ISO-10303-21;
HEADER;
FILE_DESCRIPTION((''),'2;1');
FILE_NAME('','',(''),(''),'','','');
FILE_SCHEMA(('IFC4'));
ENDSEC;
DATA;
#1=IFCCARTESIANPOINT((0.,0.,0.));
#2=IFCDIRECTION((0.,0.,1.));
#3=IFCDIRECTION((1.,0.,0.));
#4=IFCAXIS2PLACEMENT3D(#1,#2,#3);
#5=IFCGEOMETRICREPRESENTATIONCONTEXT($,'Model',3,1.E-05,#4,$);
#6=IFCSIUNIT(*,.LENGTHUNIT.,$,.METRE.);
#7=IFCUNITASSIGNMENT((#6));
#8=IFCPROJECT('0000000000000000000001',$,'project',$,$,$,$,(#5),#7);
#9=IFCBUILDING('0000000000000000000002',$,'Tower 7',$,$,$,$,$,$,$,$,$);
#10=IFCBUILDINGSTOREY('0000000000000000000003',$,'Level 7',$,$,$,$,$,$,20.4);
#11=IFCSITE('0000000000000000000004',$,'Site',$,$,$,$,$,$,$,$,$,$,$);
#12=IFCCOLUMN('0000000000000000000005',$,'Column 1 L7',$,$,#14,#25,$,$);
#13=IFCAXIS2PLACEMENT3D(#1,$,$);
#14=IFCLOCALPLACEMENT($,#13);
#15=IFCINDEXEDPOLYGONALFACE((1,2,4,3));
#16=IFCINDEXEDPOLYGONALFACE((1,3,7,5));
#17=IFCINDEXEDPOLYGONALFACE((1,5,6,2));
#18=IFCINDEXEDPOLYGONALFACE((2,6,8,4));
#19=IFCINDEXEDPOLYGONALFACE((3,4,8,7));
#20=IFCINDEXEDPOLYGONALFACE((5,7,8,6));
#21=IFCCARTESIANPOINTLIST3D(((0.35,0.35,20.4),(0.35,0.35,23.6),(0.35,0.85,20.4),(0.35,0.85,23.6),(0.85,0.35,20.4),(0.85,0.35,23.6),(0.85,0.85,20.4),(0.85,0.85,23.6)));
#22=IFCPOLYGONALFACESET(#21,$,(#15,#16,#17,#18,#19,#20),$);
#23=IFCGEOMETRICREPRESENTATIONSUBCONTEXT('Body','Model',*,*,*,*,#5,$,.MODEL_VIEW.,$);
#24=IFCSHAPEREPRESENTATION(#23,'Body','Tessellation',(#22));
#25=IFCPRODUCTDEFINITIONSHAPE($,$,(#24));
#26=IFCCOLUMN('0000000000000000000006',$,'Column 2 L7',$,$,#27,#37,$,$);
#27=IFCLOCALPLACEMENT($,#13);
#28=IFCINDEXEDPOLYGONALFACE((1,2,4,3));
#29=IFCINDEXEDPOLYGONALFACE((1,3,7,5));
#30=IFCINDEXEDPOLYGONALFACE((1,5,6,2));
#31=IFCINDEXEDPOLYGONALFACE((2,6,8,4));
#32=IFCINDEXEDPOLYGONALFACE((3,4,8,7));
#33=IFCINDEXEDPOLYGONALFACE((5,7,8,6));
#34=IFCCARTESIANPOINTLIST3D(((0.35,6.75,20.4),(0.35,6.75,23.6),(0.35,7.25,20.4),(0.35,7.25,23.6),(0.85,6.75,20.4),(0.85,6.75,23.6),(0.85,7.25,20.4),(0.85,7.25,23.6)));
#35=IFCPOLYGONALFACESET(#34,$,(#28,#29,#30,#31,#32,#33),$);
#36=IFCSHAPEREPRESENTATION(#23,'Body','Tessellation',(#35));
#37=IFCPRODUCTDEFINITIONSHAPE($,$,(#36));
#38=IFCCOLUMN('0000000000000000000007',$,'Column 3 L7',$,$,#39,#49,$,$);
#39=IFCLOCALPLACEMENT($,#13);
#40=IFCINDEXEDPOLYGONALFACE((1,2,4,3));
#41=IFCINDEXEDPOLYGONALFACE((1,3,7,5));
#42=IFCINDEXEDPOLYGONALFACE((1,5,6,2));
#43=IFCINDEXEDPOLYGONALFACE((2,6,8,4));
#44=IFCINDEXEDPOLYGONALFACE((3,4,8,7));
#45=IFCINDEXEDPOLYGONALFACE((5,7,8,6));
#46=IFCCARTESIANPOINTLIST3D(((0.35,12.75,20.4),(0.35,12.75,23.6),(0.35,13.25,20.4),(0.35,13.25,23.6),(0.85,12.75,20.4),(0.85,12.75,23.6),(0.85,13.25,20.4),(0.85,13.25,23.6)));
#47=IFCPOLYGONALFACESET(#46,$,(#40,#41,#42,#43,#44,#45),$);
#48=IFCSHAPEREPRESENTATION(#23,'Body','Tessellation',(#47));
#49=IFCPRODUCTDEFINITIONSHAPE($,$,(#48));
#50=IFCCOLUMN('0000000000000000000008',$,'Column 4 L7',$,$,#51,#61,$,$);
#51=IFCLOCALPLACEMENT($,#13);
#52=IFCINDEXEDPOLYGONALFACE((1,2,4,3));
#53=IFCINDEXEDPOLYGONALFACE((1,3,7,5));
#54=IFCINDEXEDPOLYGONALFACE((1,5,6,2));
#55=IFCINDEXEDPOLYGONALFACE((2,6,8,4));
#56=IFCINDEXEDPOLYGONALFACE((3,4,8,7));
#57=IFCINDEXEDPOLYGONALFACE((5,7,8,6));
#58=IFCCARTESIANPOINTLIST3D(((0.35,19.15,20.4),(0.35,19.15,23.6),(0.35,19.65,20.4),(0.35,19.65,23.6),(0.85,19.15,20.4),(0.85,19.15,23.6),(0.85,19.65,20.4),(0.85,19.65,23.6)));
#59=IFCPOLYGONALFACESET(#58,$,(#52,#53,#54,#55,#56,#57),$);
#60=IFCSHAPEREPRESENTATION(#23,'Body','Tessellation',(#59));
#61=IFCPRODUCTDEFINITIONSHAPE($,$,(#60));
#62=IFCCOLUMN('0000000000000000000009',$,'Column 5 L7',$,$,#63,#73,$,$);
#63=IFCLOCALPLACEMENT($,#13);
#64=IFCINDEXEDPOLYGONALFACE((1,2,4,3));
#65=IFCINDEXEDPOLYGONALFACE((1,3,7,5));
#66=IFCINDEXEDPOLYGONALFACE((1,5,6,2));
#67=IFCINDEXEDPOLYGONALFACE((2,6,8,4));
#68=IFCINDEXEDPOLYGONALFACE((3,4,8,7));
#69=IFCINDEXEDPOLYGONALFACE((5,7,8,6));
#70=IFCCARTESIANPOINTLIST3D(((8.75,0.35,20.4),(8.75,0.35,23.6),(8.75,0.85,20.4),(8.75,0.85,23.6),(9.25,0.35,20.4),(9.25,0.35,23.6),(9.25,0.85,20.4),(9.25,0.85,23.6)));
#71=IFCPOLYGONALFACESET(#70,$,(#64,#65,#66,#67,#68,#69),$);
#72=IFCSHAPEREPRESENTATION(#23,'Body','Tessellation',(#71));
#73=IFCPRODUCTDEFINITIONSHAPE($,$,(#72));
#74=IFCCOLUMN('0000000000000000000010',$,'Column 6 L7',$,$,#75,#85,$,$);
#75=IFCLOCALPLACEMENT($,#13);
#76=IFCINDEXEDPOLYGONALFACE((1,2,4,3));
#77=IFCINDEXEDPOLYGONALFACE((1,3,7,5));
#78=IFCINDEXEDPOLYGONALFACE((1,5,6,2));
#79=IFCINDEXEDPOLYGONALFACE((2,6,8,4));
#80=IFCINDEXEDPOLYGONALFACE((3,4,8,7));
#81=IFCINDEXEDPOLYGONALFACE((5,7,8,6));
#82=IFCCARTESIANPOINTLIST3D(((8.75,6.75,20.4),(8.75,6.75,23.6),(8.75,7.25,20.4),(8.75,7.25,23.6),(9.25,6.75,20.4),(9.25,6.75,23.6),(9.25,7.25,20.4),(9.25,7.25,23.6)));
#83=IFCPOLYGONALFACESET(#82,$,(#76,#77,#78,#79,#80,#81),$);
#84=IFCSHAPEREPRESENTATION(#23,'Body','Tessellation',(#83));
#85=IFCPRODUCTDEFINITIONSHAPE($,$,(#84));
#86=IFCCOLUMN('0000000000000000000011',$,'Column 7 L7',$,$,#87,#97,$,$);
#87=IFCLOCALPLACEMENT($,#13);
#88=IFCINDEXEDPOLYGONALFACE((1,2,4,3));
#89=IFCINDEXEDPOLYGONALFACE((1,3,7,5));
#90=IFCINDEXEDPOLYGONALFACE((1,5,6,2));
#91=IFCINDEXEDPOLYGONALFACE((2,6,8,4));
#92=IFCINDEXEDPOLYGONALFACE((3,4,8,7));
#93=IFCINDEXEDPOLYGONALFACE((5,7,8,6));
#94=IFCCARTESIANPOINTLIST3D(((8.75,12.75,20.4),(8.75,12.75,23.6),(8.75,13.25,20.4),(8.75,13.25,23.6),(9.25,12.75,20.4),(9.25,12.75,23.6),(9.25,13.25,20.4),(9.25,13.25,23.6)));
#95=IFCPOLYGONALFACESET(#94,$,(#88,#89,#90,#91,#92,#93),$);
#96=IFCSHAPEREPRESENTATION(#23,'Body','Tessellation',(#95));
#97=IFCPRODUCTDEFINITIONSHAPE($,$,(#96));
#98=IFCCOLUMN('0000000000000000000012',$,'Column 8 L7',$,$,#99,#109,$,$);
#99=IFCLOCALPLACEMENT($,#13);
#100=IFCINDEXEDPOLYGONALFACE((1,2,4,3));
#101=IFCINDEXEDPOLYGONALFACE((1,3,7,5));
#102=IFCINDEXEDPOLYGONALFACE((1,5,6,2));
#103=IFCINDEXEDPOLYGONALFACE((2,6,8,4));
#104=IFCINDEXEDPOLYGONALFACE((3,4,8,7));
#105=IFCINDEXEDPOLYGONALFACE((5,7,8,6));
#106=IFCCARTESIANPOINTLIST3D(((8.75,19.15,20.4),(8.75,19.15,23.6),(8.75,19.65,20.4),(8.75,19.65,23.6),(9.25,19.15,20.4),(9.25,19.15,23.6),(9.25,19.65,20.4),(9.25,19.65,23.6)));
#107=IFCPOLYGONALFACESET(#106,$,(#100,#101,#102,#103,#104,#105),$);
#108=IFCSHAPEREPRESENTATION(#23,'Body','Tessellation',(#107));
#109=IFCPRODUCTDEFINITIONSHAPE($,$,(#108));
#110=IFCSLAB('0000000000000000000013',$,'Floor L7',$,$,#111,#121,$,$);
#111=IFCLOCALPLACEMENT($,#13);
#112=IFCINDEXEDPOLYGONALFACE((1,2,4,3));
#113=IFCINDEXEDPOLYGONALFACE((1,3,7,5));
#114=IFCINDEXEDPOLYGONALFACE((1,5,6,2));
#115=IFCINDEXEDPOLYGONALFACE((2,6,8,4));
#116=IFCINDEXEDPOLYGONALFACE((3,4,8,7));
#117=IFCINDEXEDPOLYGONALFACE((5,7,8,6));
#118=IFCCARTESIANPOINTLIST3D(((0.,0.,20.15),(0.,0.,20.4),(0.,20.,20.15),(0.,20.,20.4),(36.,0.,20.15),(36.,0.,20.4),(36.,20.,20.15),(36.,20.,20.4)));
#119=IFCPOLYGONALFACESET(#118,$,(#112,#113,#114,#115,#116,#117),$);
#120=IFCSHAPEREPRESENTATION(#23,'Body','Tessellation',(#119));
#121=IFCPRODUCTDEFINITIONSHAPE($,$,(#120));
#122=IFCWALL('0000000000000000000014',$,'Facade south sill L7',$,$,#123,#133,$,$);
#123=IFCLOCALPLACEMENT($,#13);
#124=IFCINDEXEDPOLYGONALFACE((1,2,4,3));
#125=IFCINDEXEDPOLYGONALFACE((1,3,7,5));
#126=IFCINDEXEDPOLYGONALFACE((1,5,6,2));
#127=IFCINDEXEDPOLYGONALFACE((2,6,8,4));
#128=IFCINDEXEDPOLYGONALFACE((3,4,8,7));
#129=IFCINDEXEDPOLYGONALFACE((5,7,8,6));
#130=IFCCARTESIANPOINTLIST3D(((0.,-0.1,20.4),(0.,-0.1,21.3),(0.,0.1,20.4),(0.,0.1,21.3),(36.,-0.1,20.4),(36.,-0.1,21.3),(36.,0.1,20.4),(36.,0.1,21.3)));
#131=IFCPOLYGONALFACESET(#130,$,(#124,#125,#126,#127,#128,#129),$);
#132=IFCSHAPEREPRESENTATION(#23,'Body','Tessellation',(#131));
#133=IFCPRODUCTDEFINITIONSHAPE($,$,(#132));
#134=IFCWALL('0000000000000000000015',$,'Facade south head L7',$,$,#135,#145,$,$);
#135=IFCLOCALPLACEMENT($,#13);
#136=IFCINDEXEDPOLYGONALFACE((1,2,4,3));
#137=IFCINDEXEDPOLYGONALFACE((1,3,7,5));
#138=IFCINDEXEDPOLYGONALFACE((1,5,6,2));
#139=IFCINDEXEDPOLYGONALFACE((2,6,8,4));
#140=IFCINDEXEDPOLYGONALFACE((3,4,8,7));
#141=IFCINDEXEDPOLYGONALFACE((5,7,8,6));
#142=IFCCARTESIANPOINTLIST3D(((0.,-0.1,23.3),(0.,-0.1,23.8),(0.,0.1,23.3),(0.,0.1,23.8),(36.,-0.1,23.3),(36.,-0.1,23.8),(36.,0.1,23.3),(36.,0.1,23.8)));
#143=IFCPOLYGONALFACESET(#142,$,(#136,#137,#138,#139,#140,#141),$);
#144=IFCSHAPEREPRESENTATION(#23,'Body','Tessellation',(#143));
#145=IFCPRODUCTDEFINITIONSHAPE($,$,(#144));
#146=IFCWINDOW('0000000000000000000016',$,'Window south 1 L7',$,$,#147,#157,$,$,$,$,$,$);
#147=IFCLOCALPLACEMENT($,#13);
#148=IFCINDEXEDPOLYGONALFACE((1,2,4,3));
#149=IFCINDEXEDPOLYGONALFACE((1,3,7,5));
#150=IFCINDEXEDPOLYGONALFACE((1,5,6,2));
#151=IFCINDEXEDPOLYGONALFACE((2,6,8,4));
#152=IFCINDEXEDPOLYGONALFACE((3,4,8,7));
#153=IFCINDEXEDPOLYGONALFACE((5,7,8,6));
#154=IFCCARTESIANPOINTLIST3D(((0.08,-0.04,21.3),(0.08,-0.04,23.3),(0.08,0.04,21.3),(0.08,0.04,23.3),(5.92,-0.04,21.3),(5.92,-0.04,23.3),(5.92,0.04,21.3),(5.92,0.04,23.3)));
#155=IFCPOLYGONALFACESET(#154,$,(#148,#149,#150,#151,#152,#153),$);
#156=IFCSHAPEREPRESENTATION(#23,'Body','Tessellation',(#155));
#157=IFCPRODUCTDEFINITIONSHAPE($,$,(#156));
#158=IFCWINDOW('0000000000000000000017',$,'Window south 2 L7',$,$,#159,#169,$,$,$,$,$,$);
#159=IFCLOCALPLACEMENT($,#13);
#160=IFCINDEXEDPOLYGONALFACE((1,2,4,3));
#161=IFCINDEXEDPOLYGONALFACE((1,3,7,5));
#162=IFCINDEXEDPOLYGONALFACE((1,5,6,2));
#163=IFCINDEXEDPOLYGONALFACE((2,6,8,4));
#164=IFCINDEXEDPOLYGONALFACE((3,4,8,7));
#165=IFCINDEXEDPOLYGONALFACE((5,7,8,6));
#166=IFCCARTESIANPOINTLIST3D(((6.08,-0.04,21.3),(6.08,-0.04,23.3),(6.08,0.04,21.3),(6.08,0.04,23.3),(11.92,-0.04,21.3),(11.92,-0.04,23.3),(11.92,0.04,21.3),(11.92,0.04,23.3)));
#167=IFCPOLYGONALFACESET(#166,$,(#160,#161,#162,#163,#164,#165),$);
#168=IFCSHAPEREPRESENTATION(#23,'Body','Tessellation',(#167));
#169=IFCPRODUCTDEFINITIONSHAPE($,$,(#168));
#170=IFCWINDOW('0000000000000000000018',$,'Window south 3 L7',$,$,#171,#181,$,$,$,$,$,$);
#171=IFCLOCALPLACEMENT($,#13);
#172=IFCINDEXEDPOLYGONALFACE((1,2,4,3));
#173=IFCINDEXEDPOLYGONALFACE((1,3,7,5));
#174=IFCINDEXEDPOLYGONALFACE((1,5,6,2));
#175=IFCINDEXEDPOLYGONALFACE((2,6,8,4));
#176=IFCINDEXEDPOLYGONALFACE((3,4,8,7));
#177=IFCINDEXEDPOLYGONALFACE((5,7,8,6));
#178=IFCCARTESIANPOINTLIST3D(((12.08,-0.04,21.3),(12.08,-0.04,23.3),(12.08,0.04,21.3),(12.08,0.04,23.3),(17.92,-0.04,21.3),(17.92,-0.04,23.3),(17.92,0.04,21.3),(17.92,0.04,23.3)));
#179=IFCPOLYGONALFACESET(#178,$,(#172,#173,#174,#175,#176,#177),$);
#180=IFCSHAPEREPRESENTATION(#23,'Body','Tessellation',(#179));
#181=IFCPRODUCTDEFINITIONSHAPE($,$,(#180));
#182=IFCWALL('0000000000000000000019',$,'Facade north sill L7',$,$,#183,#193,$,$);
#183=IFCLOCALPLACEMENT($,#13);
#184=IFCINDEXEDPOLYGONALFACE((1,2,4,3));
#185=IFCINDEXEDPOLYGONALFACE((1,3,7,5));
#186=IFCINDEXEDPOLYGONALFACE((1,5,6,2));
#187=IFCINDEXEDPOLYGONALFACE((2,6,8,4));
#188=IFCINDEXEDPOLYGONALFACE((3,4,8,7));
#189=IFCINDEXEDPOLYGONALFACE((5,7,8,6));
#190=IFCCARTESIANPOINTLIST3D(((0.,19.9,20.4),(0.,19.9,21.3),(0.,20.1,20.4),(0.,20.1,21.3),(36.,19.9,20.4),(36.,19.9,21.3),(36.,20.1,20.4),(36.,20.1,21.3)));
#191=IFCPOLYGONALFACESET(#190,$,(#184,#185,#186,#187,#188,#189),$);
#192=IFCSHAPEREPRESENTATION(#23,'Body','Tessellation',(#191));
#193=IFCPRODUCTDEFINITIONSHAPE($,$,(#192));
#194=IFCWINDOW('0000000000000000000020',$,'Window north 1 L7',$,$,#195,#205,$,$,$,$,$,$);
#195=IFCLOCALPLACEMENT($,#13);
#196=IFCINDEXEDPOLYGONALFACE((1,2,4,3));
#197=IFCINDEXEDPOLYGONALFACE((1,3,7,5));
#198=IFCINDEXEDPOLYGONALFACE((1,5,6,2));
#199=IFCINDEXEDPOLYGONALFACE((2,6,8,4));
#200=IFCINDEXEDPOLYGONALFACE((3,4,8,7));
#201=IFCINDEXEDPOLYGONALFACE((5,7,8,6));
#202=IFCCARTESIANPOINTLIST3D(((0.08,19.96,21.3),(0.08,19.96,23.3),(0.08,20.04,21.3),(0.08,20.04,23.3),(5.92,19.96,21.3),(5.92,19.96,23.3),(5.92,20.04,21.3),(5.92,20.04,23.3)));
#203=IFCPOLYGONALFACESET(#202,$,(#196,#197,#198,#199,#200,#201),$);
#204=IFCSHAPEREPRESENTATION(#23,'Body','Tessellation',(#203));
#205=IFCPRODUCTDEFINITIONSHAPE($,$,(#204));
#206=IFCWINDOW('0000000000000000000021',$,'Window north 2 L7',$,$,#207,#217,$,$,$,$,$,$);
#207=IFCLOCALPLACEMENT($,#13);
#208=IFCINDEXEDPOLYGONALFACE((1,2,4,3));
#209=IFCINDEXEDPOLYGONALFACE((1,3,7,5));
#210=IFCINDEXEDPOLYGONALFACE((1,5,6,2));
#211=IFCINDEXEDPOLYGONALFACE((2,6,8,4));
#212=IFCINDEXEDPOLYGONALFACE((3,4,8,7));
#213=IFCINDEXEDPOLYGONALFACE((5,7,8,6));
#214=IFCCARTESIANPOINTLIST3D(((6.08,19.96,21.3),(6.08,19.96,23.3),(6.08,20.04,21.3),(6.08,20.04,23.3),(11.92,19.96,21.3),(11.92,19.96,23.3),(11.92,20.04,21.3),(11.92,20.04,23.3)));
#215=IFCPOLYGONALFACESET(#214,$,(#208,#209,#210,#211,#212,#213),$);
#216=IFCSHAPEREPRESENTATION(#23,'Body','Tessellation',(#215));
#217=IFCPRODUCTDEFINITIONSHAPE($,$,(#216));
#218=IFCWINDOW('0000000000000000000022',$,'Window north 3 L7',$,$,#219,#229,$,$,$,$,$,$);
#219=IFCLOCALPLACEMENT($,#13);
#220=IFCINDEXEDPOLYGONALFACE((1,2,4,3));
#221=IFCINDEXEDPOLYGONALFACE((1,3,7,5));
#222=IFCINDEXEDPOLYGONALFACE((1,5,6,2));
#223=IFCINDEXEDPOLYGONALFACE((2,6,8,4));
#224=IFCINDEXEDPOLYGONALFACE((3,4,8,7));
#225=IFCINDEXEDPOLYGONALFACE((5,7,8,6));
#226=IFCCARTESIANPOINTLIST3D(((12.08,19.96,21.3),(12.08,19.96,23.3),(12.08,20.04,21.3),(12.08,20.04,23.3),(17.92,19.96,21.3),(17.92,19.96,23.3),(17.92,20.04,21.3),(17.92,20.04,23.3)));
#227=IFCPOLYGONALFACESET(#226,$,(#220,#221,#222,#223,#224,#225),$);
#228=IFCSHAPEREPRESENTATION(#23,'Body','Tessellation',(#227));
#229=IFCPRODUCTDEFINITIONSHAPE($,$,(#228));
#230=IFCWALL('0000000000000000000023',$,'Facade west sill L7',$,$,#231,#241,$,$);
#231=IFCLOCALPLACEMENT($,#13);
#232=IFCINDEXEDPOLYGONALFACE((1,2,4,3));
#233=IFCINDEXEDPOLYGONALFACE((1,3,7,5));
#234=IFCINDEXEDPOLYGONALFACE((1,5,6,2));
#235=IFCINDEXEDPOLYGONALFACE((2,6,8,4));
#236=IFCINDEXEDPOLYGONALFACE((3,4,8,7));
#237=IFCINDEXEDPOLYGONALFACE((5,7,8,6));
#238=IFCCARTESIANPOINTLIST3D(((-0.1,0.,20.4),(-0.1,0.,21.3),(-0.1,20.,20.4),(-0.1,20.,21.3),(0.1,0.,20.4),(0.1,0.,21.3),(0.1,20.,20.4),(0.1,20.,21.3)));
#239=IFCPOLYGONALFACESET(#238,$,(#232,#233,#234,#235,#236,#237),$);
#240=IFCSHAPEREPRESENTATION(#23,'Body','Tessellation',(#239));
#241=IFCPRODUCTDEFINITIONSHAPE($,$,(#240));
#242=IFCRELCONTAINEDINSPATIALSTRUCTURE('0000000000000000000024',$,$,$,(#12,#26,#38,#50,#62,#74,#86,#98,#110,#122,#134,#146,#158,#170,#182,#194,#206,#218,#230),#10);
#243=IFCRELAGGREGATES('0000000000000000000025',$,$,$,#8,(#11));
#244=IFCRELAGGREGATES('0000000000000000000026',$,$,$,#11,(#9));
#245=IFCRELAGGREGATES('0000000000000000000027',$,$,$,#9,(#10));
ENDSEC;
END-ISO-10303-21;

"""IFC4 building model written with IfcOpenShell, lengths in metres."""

from ifc_helpers import new_model, si_unit, frame, origin, origin_with_axes, origin_2d, place, context, subcontext, project, spatial, rectangle, extrude, element, save


model = new_model("IFC4")

# Units and contexts
model_context = context("Model", 3, precision=1e-05, world=origin_with_axes())
body_context = subcontext(model_context, "Body", "Model", "MODEL_VIEW")
ifc_project = project(units=[si_unit("LENGTHUNIT", "METRE")], contexts=[model_context])

# Site, building, storey
site = spatial("IfcSite", under=ifc_project, Name="Site")
building = spatial("IfcBuilding", under=site, Name="Tower 7")
storey = spatial("IfcBuildingStorey", under=building, Name="Level 7", Elevation=20.4)

# Columns
for number, where, z_axis, x_axis, name in (
    (1, (0.6, 0.6, 20.4), (0.0, 0.0, 1.0), (1.0, 0.0, 0.0), "Column 1 L7"),
    (2, (0.6, 7.0, 20.4), (0.0, 0.0, 1.0), (1.0, 0.0, 0.0), "Column 2 L7"),
    (3, (0.6, 13.0, 20.4), (0.0, 0.0, 1.0), (1.0, 0.0, 0.0), "Column 3 L7"),
    (4, (0.6, 19.4, 20.4), (0.0, 0.0, 1.0), (1.0, 0.0, 0.0), "Column 4 L7"),
    (5, (9.0, 0.6, 20.4), (0.0, 0.0, 1.0), (1.0, 0.0, 0.0), "Column 5 L7"),
    (6, (9.0, 7.0, 20.4), (0.0, 0.0, 1.0), (1.0, 0.0, 0.0), "Column 6 L7"),
    (7, (9.0, 13.0, 20.4), (0.0, 0.0, 1.0), (1.0, 0.0, 0.0), "Column 7 L7"),
    (8, (9.0, 19.4, 20.4), (0.0, 0.0, 1.0), (1.0, 0.0, 0.0), "Column 8 L7"),
):
    element("IfcColumn", number, at=place(None, frame(where, z_axis=z_axis, x_axis=x_axis)), inside=storey, Name=name, context=body_context, shape_type="SweptSolid", body=[
        extrude(rectangle(XDim=0.5, YDim=0.5, at=origin_2d()), origin(), (0.0, 0.0, 1.0), 3.2),
    ])

# Slab
slab_placement = place(None, frame((18.0, 10.0, 20.15), z_axis=(0.0, 0.0, 1.0), x_axis=(1.0, 0.0, 0.0)))
element("IfcSlab", 9, at=slab_placement, inside=storey, Name="Floor L7", context=body_context, shape_type="SweptSolid", body=[
    extrude(rectangle(XDim=36.0, YDim=20.0, at=origin_2d()), origin(), (0.0, 0.0, 1.0), 0.25),
])

# Walls
wall_1_placement = place(None, frame((18.0, 0.0, 20.4), z_axis=(0.0, 0.0, 1.0), x_axis=(1.0, 0.0, 0.0)))
element("IfcWall", 10, at=wall_1_placement, inside=storey, Name="Facade south sill L7", context=body_context, shape_type="SweptSolid", body=[
    extrude(rectangle(XDim=36.0, YDim=0.2, at=origin_2d()), origin(), (0.0, 0.0, 1.0), 0.9),
])
wall_2_placement = place(None, frame((18.0, 0.0, 23.3), z_axis=(0.0, 0.0, 1.0), x_axis=(1.0, 0.0, 0.0)))
element("IfcWall", 11, at=wall_2_placement, inside=storey, Name="Facade south head L7", context=body_context, shape_type="SweptSolid", body=[
    extrude(rectangle(XDim=36.0, YDim=0.2, at=origin_2d()), origin(), (0.0, 0.0, 1.0), 0.5),
])

# Windows
for number, where, z_axis, x_axis, name in (
    (12, (3.0, 0.0, 21.3), (0.0, 0.0, 1.0), (1.0, 0.0, 0.0), "Window south 1 L7"),
    (13, (9.0, 0.0, 21.3), (0.0, 0.0, 1.0), (1.0, 0.0, 0.0), "Window south 2 L7"),
):
    element("IfcWindow", number, at=place(None, frame(where, z_axis=z_axis, x_axis=x_axis)), inside=storey, Name=name, context=body_context, shape_type="SweptSolid", body=[
        extrude(rectangle(XDim=5.84, YDim=0.08, at=origin_2d()), origin(), (0.0, 0.0, 1.0), 2.0),
    ])
window_1_placement = place(None, frame((15.0, 0.0, 21.3), z_axis=(0.0, 0.0, 1.0), x_axis=(1.0, 0.0, 0.0)))
element("IfcWindow", 14, at=window_1_placement, inside=storey, Name="Window south 3 L7", context=body_context, shape_type="SweptSolid", body=[
    extrude(rectangle(XDim=5.84, YDim=0.08, at=origin_2d()), origin(), (0.0, 0.0, 1.0), 2.0),
])

# Wall
wall_3_placement = place(None, frame((18.0, 20.0, 20.4), z_axis=(0.0, 0.0, 1.0), x_axis=(1.0, 0.0, 0.0)))
element("IfcWall", 15, at=wall_3_placement, inside=storey, Name="Facade north sill L7", context=body_context, shape_type="SweptSolid", body=[
    extrude(rectangle(XDim=36.0, YDim=0.2, at=origin_2d()), origin(), (0.0, 0.0, 1.0), 0.9),
])

# Windows
for number, where, z_axis, x_axis, name in (
    (16, (3.0, 20.0, 21.3), (0.0, 0.0, 1.0), (1.0, 0.0, 0.0), "Window north 1 L7"),
    (17, (9.0, 20.0, 21.3), (0.0, 0.0, 1.0), (1.0, 0.0, 0.0), "Window north 2 L7"),
):
    element("IfcWindow", number, at=place(None, frame(where, z_axis=z_axis, x_axis=x_axis)), inside=storey, Name=name, context=body_context, shape_type="SweptSolid", body=[
        extrude(rectangle(XDim=5.84, YDim=0.08, at=origin_2d()), origin(), (0.0, 0.0, 1.0), 2.0),
    ])
window_2_placement = place(None, frame((15.0, 20.0, 21.3), z_axis=(0.0, 0.0, 1.0), x_axis=(1.0, 0.0, 0.0)))
element("IfcWindow", 18, at=window_2_placement, inside=storey, Name="Window north 3 L7", context=body_context, shape_type="SweptSolid", body=[
    extrude(rectangle(XDim=5.84, YDim=0.08, at=origin_2d()), origin(), (0.0, 0.0, 1.0), 2.0),
])

# Wall
wall_4_placement = place(None, frame((0.0, 10.0, 20.4), z_axis=(0.0, 0.0, 1.0), x_axis=(1.0, 0.0, 0.0)))
element("IfcWall", 19, at=wall_4_placement, inside=storey, Name="Facade west sill L7", context=body_context, shape_type="SweptSolid", body=[
    extrude(rectangle(XDim=0.2, YDim=20.0, at=origin_2d()), origin(), (0.0, 0.0, 1.0), 0.9),
])

save(model, "model.ifc")
